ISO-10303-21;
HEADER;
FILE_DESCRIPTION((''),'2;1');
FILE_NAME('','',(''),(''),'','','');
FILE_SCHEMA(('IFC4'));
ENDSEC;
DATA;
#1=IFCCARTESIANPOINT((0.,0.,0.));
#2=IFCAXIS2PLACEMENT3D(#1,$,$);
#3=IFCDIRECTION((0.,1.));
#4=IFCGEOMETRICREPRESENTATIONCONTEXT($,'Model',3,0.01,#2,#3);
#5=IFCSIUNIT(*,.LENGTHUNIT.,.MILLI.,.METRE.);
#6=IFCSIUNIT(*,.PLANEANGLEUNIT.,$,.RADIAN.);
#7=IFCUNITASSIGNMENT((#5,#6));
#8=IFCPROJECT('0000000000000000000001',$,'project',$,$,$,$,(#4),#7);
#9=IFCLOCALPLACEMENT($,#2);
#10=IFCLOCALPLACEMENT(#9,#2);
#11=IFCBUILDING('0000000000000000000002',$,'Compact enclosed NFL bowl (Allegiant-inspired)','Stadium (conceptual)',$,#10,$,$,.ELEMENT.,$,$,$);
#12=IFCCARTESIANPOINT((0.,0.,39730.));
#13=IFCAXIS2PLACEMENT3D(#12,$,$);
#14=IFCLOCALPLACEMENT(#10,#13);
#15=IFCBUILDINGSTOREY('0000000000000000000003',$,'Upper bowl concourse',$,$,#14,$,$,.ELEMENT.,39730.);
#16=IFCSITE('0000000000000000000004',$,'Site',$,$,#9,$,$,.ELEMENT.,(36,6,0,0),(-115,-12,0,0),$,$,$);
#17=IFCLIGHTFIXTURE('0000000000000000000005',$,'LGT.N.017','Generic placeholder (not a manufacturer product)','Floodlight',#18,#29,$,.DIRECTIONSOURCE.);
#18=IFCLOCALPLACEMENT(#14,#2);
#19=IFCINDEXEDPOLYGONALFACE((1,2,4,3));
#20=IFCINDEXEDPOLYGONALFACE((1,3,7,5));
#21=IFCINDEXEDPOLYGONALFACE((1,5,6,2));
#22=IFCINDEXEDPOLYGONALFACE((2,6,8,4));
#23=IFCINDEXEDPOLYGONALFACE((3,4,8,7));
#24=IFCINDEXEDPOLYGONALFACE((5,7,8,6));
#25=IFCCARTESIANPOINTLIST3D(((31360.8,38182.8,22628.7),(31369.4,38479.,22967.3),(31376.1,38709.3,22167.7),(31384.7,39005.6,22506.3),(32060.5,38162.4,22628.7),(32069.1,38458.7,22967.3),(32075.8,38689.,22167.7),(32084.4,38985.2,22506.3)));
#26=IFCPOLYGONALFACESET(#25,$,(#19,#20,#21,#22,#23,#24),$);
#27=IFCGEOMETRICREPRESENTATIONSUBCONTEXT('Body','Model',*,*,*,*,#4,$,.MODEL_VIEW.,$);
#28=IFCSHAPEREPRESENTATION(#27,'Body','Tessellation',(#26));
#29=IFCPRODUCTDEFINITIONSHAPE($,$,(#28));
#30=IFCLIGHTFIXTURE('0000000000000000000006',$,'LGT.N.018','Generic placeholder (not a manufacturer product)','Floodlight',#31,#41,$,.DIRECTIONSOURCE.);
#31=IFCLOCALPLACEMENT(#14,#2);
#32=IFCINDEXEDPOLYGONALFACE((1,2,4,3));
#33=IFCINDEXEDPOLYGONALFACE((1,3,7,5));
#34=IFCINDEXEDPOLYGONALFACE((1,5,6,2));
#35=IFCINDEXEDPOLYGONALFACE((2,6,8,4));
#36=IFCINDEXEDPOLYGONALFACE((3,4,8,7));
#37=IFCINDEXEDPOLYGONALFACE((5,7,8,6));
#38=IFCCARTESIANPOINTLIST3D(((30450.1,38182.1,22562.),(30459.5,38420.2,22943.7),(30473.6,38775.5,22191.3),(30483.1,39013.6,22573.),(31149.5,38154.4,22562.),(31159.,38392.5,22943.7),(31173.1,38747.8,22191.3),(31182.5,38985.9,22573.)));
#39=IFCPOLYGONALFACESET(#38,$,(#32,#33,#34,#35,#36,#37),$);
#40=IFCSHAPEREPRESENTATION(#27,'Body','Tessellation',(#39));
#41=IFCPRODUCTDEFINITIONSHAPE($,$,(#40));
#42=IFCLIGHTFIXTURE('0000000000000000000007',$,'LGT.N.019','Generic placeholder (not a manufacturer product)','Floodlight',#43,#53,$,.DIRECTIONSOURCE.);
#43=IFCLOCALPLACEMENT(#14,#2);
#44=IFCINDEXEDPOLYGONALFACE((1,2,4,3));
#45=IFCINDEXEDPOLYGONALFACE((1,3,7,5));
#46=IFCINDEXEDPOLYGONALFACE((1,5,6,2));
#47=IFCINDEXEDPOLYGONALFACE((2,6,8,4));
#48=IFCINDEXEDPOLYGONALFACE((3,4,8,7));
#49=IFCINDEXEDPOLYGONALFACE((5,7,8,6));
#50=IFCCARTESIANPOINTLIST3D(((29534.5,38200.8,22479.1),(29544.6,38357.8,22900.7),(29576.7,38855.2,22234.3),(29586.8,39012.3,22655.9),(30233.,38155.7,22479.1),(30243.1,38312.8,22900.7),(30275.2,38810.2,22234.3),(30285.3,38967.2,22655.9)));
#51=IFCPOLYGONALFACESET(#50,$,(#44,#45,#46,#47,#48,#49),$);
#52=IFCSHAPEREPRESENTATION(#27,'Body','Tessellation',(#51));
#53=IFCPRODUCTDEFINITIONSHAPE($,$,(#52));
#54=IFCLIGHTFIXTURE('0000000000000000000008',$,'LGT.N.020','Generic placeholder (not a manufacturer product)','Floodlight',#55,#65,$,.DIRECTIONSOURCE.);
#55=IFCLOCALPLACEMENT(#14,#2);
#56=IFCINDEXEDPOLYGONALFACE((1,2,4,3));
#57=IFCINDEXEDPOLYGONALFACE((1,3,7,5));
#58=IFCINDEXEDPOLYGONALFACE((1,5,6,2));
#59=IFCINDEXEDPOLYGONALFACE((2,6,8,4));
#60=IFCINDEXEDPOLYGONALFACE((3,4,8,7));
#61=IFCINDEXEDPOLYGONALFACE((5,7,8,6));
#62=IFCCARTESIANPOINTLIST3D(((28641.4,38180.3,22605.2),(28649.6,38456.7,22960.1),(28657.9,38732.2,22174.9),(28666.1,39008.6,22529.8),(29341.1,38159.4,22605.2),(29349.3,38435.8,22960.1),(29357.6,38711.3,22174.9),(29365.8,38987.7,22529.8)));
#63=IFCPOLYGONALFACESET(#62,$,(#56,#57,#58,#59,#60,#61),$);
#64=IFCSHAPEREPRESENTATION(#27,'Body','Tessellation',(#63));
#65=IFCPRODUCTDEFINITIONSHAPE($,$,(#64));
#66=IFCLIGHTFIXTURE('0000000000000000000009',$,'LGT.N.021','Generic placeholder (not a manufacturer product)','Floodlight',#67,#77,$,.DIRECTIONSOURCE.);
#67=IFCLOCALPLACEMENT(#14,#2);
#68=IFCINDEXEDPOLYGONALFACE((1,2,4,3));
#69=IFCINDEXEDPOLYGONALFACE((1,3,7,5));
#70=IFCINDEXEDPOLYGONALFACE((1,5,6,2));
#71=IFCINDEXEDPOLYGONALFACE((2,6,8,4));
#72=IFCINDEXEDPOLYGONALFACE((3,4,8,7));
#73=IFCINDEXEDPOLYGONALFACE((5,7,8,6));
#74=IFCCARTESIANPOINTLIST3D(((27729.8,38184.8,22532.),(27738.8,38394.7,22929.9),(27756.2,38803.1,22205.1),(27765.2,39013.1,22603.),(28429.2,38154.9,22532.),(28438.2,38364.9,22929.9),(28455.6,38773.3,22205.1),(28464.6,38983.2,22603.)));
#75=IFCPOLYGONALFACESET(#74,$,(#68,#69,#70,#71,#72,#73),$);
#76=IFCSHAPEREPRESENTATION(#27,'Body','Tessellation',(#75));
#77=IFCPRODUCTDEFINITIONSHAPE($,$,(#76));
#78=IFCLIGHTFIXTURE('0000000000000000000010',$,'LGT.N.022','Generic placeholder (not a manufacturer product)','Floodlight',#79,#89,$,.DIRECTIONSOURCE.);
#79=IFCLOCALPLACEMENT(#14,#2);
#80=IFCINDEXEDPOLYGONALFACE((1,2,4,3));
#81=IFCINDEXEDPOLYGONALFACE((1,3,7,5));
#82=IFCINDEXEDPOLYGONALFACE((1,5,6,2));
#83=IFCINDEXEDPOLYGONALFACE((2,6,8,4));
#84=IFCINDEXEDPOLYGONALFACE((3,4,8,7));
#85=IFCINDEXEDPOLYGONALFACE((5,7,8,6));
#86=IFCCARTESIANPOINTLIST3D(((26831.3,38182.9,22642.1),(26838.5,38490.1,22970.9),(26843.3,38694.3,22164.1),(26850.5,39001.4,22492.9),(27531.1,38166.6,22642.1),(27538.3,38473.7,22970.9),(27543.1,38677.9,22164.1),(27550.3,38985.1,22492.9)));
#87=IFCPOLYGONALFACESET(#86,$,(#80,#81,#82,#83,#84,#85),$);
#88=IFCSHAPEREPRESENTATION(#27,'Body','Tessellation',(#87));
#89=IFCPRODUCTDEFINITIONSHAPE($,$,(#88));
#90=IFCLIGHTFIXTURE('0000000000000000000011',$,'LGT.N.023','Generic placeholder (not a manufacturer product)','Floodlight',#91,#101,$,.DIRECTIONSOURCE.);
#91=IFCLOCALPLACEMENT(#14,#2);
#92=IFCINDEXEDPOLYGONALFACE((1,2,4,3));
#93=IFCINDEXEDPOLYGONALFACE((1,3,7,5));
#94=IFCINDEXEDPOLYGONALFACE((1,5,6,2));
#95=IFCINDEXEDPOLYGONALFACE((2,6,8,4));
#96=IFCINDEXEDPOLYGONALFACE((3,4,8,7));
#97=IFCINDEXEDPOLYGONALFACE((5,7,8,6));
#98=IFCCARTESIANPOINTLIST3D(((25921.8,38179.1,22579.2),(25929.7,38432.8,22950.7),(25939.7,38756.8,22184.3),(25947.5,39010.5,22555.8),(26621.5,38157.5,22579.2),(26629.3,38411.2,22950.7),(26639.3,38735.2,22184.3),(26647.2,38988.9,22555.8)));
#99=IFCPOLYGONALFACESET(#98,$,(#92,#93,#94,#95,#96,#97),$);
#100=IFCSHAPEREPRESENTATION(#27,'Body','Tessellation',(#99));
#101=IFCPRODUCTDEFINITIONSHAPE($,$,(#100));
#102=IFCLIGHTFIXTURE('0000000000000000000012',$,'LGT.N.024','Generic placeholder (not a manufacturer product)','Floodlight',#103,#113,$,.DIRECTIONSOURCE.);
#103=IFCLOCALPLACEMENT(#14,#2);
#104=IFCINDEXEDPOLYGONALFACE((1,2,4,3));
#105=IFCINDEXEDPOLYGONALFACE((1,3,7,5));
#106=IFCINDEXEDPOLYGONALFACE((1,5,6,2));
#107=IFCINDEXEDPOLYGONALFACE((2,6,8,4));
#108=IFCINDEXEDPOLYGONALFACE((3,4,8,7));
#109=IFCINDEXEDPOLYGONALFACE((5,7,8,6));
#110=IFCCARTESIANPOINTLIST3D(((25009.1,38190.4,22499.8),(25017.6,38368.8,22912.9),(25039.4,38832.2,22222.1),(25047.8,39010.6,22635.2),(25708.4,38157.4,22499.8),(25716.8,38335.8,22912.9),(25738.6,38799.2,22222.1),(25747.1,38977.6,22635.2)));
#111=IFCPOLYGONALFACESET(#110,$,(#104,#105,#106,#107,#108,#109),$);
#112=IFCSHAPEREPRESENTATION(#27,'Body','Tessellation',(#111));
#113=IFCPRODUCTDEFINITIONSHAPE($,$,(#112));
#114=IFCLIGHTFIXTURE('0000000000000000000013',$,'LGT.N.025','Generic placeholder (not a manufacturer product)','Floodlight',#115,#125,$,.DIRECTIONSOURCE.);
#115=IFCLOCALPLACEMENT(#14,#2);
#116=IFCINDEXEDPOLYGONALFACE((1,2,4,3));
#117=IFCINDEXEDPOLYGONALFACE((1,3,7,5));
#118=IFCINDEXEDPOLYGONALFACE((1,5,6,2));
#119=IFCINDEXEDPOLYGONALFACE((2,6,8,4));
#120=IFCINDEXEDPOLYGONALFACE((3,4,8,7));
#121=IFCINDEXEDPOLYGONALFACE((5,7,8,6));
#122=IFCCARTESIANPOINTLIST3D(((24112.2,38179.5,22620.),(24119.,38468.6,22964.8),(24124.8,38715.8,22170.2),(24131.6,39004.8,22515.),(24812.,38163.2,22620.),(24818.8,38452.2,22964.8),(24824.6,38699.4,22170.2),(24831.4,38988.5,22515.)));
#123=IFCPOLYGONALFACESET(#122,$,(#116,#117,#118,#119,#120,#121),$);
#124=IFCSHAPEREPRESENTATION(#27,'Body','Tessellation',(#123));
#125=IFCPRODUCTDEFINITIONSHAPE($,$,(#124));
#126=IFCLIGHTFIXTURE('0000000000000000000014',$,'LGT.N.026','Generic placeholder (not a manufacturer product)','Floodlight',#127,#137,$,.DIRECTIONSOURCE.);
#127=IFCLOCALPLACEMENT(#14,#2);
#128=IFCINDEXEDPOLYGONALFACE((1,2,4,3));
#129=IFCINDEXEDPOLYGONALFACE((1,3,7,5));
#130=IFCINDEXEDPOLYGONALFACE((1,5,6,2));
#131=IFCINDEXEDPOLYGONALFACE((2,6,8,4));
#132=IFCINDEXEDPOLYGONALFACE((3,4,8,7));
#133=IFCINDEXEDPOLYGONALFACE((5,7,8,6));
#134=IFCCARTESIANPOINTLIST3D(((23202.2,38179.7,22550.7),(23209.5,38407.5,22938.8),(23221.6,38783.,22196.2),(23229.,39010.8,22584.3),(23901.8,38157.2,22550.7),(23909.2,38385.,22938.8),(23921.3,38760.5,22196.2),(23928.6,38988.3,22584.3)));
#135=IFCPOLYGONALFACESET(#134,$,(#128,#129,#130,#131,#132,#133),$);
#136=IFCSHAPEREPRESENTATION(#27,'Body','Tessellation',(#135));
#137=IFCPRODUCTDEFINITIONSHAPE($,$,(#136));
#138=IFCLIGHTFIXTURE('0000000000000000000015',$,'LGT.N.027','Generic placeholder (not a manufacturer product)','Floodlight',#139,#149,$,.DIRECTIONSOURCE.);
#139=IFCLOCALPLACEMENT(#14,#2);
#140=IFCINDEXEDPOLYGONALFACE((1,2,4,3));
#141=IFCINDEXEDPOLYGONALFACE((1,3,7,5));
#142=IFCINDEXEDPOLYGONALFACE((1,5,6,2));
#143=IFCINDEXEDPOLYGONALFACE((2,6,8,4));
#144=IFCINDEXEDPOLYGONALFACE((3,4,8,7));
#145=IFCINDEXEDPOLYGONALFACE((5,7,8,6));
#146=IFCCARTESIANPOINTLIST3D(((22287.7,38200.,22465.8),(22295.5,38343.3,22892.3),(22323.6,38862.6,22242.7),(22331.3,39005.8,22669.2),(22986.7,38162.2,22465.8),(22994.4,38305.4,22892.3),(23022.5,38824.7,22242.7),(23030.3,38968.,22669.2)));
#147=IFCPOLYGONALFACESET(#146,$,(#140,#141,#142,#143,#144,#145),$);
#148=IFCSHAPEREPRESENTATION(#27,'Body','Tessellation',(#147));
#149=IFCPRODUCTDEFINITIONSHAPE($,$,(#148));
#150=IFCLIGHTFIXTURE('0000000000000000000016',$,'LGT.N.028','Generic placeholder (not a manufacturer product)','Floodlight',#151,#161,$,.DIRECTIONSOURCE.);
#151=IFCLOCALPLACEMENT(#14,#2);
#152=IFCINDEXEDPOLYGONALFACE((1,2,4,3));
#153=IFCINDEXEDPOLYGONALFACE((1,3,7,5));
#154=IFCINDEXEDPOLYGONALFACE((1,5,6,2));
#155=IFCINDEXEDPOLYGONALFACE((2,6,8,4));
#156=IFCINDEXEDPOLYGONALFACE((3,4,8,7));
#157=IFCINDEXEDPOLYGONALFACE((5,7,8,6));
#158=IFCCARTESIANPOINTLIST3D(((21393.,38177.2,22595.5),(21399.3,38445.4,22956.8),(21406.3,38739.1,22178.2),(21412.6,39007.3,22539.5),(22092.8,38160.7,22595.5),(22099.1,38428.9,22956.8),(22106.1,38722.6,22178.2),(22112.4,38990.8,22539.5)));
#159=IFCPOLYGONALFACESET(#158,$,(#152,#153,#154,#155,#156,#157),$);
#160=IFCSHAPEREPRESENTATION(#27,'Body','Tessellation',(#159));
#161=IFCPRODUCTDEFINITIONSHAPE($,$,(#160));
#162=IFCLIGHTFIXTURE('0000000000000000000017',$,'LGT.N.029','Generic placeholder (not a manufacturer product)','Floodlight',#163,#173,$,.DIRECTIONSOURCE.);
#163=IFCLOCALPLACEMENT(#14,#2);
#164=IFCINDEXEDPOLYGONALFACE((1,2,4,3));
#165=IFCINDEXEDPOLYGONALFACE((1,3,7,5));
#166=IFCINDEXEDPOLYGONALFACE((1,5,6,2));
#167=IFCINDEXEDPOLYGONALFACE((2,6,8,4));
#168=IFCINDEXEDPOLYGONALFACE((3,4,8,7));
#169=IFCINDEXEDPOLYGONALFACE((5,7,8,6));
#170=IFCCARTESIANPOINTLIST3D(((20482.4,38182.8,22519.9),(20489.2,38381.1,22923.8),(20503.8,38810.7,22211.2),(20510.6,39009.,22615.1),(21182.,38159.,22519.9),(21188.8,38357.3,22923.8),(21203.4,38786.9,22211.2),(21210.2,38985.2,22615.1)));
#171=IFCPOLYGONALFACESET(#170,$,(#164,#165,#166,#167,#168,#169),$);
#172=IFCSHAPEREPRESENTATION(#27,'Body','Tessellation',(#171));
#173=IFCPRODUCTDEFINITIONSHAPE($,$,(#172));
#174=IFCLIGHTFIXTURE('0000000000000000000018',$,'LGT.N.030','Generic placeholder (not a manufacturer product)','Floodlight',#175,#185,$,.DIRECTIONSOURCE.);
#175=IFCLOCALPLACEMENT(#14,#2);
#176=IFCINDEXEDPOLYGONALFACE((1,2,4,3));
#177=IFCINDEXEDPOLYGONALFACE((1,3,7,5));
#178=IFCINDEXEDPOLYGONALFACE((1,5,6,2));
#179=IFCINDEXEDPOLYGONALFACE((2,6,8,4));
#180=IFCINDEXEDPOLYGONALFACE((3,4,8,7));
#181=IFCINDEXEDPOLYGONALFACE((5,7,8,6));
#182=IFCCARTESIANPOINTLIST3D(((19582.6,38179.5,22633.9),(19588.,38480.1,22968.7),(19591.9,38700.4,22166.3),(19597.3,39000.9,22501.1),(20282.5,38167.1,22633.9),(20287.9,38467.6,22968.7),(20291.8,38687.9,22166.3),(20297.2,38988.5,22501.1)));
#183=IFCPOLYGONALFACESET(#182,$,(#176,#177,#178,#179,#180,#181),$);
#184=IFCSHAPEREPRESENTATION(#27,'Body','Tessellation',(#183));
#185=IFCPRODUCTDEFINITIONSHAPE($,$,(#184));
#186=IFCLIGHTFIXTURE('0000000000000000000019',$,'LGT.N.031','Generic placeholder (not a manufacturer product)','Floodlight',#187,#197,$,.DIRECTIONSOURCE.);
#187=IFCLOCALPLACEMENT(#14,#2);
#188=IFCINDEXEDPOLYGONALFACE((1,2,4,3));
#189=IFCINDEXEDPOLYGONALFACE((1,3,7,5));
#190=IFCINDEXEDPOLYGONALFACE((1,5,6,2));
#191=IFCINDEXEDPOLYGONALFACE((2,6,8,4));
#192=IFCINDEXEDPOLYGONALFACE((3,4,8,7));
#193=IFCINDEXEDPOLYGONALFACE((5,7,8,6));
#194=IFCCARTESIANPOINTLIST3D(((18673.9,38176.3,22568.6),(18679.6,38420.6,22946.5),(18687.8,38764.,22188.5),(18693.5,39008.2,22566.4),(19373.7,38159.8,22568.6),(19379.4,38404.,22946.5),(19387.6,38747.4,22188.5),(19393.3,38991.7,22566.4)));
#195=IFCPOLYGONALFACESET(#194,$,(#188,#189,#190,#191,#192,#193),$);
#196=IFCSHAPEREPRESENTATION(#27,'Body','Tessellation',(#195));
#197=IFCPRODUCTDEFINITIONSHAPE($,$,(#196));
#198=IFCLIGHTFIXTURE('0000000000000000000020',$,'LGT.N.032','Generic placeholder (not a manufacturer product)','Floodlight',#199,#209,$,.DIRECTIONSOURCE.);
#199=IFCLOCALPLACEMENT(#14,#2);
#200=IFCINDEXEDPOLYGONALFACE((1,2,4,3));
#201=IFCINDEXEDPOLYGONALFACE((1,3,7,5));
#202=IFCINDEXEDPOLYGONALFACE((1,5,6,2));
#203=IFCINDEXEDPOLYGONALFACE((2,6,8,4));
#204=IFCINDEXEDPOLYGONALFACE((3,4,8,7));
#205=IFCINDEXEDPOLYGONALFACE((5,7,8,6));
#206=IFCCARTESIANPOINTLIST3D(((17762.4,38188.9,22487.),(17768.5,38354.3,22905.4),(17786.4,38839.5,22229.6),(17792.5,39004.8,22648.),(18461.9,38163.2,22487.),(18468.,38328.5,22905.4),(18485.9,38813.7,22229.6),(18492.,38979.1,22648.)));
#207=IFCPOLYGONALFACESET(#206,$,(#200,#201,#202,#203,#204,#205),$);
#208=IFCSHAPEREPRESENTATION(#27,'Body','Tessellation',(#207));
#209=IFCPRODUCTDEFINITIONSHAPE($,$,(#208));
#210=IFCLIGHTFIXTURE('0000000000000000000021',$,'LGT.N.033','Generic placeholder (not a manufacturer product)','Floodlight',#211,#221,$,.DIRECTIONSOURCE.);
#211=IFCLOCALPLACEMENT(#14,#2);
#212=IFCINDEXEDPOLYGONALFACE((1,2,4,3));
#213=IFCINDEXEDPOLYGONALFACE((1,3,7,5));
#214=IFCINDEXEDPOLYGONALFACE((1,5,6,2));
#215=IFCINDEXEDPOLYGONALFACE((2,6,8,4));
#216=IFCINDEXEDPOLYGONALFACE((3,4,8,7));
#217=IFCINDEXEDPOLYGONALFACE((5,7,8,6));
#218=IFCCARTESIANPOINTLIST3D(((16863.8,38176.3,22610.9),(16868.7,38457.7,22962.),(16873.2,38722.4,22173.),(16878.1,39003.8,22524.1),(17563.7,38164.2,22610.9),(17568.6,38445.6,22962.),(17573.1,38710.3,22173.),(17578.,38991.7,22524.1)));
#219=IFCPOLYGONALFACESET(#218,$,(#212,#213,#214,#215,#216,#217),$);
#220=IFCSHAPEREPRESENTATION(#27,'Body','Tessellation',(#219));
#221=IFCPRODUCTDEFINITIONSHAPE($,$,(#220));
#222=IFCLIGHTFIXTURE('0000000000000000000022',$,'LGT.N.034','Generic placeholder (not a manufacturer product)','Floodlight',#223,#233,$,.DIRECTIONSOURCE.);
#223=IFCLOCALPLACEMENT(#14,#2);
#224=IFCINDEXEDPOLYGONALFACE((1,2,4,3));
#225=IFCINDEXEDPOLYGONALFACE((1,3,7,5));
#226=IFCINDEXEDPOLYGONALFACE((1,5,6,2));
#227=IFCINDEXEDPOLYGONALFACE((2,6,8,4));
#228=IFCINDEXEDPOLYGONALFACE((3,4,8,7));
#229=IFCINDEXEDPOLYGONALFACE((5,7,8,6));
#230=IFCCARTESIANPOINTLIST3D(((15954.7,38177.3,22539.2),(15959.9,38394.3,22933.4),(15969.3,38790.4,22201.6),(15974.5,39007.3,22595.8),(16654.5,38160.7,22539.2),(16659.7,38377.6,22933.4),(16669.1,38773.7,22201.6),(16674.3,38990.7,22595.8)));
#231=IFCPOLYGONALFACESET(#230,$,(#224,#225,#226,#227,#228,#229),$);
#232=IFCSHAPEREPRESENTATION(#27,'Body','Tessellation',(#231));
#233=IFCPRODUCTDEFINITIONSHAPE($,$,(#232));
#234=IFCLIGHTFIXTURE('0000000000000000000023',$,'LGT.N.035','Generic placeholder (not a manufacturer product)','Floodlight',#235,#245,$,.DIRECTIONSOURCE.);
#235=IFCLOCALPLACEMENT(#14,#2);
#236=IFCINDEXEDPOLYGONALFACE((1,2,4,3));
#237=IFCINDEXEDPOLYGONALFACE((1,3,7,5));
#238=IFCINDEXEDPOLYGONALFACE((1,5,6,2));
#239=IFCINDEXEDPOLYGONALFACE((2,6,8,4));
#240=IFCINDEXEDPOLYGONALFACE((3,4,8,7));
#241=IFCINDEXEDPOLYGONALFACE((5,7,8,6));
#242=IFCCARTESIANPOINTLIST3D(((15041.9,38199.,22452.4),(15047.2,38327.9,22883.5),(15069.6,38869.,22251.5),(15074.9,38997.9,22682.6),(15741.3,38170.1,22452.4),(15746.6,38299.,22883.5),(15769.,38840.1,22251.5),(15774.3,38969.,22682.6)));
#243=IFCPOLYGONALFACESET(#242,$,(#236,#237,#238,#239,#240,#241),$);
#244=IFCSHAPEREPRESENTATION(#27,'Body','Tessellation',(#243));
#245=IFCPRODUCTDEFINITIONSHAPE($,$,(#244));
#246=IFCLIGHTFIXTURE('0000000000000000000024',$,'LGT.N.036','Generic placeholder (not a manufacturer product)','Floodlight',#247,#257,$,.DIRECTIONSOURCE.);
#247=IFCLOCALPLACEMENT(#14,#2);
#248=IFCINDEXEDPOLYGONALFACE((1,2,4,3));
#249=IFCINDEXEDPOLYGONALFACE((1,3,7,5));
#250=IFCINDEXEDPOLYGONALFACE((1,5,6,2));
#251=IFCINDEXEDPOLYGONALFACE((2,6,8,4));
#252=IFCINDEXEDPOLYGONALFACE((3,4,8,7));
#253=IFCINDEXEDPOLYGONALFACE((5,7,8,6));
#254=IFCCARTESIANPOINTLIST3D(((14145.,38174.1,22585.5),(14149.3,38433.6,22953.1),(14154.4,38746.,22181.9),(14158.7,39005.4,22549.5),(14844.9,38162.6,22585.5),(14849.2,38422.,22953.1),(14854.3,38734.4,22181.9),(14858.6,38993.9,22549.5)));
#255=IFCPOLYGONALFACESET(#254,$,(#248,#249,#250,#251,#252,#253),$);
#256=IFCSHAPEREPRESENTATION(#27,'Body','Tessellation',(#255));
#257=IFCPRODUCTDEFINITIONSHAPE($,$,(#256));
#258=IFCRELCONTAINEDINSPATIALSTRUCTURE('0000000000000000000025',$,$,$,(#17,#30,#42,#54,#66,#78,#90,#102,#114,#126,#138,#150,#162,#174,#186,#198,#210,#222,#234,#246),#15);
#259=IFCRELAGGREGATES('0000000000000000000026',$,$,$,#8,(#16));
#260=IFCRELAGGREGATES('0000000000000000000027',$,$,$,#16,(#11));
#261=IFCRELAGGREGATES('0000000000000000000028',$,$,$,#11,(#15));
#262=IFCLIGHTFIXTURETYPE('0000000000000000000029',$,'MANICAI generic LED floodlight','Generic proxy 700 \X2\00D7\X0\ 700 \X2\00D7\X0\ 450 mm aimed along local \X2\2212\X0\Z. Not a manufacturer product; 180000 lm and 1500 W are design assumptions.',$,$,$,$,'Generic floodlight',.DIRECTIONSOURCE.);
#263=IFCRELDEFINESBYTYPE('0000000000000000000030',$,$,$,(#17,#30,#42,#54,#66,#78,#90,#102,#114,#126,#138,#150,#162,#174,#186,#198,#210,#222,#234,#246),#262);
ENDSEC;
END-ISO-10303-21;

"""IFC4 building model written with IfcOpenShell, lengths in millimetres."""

from ifc_helpers import new_model, si_unit, direction, frame, origin, place, context, subcontext, project, spatial, rectangle, extrude, source, transform, mapped, type_object, type_shapes, element, save


model = new_model("IFC4")

# Units and contexts
model_context = context("Model", 3, precision=0.01, world=origin(), true_north=direction((0.0, 1.0)))
body_context = subcontext(model_context, "Body", "Model", "MODEL_VIEW")
ifc_project = project(units=[si_unit("LENGTHUNIT", "METRE", prefix="MILLI"), si_unit("PLANEANGLEUNIT", "RADIAN")], contexts=[model_context])

# Site, building, storey
site_placement = place(None, origin())
site = spatial("IfcSite", under=ifc_project, at=site_placement, Name="Site", CompositionType="ELEMENT", RefLatitude=(36, 6, 0, 0), RefLongitude=(-115, -12, 0, 0))
building_placement = place(site_placement, origin())
building = spatial("IfcBuilding", under=site, at=building_placement, Name="Compact enclosed NFL bowl (Allegiant-inspired)", Description="Stadium (conceptual)", CompositionType="ELEMENT")
storey_placement = place(building_placement, frame((0.0, 0.0, 39730.0)))
storey = spatial("IfcBuildingStorey", under=building, at=storey_placement, Name="Upper bowl concourse", CompositionType="ELEMENT", Elevation=39730.0)

# Light fixtures
light_fixture_type = type_object("IfcLightFixtureType", Name="MANICAI generic LED floodlight", Description="Generic proxy 700 × 700 × 450 mm aimed along local −Z. Not a manufacturer product; 180000 lm and 1500 W are design assumptions.", ElementType="Generic floodlight", PredefinedType="DIRECTIONSOURCE")
shared_shape = source(origin(), body_context, "Body", "SweptSolid", [
    extrude(rectangle(XDim=700.0, YDim=700.0), frame((0.0, 0.0, -225.0)), (0.0, 0.0, 1.0), 450.0),
])
type_shapes(light_fixture_type, [shared_shape])
for number, where, z_axis, x_axis, name in (
    (1, (31722.6, 38584.0, 22567.5), (0.019159, 0.658318, 0.752496), (-0.999577, 0.029091, 0.0), "LGT.N.017"),
    (2, (30816.3, 38584.0, 22567.5), (0.020982, 0.529075, 0.848316), (-0.999215, 0.039626, 0.0), "LGT.N.018"),
    (3, (29909.9, 38584.0, 22567.5), (0.02249, 0.348985, 0.936858), (-0.99793, 0.06431, 0.0), "LGT.N.019"),
    (4, (29003.6, 38584.0, 22567.5), (0.018362, 0.614392, 0.788787), (-0.999554, 0.029872, 0.0), "LGT.N.020"),
    (5, (28097.2, 38584.0, 22567.5), (0.01994, 0.466638, 0.884224), (-0.999088, 0.042692, 0.0), "LGT.N.021"),
    (6, (27190.8, 38584.0, 22567.5), (0.015946, 0.682546, 0.730668), (-0.999727, 0.023356, 0.0), "LGT.N.022"),
    (7, (26284.5, 38584.0, 22567.5), (0.017418, 0.5639, 0.825659), (-0.999523, 0.030874, 0.0), "LGT.N.023"),
    (8, (25378.1, 38584.0, 22567.5), (0.018696, 0.396352, 0.917908), (-0.998889, 0.047119, 0.0), "LGT.N.024"),
    (9, (24471.8, 38584.0, 22567.5), (0.015051, 0.642311, 0.766296), (-0.999726, 0.023426, 0.0), "LGT.N.025"),
    (10, (23565.4, 38584.0, 22567.5), (0.016309, 0.506181, 0.862273), (-0.999481, 0.032202, 0.0), "LGT.N.026"),
    (11, (22659.0, 38584.0, 22567.5), (0.017237, 0.318336, 0.947821), (-0.998537, 0.054069, 0.0), "LGT.N.027"),
    (12, (21752.7, 38584.0, 22567.5), (0.014017, 0.595958, 0.802893), (-0.999723, 0.023514, 0.0), "LGT.N.028"),
    (13, (20846.3, 38584.0, 22567.5), (0.015016, 0.440756, 0.897501), (-0.99942, 0.03405, 0.0), "LGT.N.029"),
    (14, (19939.9, 38584.0, 22567.5), (0.01191, 0.667887, 0.744168), (-0.999841, 0.017829, 0.0), "LGT.N.030"),
    (15, (19033.6, 38584.0, 22567.5), (0.012829, 0.542772, 0.839782), (-0.999721, 0.023629, 0.0), "LGT.N.031"),
    (16, (18127.2, 38584.0, 22567.5), (0.01353, 0.367468, 0.929938), (-0.999323, 0.036793, 0.0), "LGT.N.032"),
    (17, (17220.9, 38584.0, 22567.5), (0.010784, 0.625399, 0.780231), (-0.999851, 0.017241, 0.0), "LGT.N.033"),
    (18, (16314.5, 38584.0, 22567.5), (0.011471, 0.482146, 0.876016), (-0.999717, 0.023784, 0.0), "LGT.N.034"),
    (19, (15408.1, 38584.0, 22567.5), (0.011847, 0.286638, 0.957966), (-0.999147, 0.041295, 0.0), "LGT.N.035"),
    (20, (14501.8, 38584.0, 22567.5), (0.00951, 0.576513, 0.817033), (-0.999864, 0.016493, 0.0), "LGT.N.036"),
):
    element("IfcLightFixture", number, at=place(storey_placement, frame(where, z_axis=z_axis, x_axis=x_axis)), inside=storey, type_object=light_fixture_type, Name=name, Description="Generic placeholder (not a manufacturer product)", ObjectType="Floodlight", PredefinedType="DIRECTIONSOURCE", context=body_context, shape_type="MappedRepresentation", body=[
        mapped(shared_shape, transform((0.0, 0.0, 0.0))),
    ])

save(model, "model.ifc")
